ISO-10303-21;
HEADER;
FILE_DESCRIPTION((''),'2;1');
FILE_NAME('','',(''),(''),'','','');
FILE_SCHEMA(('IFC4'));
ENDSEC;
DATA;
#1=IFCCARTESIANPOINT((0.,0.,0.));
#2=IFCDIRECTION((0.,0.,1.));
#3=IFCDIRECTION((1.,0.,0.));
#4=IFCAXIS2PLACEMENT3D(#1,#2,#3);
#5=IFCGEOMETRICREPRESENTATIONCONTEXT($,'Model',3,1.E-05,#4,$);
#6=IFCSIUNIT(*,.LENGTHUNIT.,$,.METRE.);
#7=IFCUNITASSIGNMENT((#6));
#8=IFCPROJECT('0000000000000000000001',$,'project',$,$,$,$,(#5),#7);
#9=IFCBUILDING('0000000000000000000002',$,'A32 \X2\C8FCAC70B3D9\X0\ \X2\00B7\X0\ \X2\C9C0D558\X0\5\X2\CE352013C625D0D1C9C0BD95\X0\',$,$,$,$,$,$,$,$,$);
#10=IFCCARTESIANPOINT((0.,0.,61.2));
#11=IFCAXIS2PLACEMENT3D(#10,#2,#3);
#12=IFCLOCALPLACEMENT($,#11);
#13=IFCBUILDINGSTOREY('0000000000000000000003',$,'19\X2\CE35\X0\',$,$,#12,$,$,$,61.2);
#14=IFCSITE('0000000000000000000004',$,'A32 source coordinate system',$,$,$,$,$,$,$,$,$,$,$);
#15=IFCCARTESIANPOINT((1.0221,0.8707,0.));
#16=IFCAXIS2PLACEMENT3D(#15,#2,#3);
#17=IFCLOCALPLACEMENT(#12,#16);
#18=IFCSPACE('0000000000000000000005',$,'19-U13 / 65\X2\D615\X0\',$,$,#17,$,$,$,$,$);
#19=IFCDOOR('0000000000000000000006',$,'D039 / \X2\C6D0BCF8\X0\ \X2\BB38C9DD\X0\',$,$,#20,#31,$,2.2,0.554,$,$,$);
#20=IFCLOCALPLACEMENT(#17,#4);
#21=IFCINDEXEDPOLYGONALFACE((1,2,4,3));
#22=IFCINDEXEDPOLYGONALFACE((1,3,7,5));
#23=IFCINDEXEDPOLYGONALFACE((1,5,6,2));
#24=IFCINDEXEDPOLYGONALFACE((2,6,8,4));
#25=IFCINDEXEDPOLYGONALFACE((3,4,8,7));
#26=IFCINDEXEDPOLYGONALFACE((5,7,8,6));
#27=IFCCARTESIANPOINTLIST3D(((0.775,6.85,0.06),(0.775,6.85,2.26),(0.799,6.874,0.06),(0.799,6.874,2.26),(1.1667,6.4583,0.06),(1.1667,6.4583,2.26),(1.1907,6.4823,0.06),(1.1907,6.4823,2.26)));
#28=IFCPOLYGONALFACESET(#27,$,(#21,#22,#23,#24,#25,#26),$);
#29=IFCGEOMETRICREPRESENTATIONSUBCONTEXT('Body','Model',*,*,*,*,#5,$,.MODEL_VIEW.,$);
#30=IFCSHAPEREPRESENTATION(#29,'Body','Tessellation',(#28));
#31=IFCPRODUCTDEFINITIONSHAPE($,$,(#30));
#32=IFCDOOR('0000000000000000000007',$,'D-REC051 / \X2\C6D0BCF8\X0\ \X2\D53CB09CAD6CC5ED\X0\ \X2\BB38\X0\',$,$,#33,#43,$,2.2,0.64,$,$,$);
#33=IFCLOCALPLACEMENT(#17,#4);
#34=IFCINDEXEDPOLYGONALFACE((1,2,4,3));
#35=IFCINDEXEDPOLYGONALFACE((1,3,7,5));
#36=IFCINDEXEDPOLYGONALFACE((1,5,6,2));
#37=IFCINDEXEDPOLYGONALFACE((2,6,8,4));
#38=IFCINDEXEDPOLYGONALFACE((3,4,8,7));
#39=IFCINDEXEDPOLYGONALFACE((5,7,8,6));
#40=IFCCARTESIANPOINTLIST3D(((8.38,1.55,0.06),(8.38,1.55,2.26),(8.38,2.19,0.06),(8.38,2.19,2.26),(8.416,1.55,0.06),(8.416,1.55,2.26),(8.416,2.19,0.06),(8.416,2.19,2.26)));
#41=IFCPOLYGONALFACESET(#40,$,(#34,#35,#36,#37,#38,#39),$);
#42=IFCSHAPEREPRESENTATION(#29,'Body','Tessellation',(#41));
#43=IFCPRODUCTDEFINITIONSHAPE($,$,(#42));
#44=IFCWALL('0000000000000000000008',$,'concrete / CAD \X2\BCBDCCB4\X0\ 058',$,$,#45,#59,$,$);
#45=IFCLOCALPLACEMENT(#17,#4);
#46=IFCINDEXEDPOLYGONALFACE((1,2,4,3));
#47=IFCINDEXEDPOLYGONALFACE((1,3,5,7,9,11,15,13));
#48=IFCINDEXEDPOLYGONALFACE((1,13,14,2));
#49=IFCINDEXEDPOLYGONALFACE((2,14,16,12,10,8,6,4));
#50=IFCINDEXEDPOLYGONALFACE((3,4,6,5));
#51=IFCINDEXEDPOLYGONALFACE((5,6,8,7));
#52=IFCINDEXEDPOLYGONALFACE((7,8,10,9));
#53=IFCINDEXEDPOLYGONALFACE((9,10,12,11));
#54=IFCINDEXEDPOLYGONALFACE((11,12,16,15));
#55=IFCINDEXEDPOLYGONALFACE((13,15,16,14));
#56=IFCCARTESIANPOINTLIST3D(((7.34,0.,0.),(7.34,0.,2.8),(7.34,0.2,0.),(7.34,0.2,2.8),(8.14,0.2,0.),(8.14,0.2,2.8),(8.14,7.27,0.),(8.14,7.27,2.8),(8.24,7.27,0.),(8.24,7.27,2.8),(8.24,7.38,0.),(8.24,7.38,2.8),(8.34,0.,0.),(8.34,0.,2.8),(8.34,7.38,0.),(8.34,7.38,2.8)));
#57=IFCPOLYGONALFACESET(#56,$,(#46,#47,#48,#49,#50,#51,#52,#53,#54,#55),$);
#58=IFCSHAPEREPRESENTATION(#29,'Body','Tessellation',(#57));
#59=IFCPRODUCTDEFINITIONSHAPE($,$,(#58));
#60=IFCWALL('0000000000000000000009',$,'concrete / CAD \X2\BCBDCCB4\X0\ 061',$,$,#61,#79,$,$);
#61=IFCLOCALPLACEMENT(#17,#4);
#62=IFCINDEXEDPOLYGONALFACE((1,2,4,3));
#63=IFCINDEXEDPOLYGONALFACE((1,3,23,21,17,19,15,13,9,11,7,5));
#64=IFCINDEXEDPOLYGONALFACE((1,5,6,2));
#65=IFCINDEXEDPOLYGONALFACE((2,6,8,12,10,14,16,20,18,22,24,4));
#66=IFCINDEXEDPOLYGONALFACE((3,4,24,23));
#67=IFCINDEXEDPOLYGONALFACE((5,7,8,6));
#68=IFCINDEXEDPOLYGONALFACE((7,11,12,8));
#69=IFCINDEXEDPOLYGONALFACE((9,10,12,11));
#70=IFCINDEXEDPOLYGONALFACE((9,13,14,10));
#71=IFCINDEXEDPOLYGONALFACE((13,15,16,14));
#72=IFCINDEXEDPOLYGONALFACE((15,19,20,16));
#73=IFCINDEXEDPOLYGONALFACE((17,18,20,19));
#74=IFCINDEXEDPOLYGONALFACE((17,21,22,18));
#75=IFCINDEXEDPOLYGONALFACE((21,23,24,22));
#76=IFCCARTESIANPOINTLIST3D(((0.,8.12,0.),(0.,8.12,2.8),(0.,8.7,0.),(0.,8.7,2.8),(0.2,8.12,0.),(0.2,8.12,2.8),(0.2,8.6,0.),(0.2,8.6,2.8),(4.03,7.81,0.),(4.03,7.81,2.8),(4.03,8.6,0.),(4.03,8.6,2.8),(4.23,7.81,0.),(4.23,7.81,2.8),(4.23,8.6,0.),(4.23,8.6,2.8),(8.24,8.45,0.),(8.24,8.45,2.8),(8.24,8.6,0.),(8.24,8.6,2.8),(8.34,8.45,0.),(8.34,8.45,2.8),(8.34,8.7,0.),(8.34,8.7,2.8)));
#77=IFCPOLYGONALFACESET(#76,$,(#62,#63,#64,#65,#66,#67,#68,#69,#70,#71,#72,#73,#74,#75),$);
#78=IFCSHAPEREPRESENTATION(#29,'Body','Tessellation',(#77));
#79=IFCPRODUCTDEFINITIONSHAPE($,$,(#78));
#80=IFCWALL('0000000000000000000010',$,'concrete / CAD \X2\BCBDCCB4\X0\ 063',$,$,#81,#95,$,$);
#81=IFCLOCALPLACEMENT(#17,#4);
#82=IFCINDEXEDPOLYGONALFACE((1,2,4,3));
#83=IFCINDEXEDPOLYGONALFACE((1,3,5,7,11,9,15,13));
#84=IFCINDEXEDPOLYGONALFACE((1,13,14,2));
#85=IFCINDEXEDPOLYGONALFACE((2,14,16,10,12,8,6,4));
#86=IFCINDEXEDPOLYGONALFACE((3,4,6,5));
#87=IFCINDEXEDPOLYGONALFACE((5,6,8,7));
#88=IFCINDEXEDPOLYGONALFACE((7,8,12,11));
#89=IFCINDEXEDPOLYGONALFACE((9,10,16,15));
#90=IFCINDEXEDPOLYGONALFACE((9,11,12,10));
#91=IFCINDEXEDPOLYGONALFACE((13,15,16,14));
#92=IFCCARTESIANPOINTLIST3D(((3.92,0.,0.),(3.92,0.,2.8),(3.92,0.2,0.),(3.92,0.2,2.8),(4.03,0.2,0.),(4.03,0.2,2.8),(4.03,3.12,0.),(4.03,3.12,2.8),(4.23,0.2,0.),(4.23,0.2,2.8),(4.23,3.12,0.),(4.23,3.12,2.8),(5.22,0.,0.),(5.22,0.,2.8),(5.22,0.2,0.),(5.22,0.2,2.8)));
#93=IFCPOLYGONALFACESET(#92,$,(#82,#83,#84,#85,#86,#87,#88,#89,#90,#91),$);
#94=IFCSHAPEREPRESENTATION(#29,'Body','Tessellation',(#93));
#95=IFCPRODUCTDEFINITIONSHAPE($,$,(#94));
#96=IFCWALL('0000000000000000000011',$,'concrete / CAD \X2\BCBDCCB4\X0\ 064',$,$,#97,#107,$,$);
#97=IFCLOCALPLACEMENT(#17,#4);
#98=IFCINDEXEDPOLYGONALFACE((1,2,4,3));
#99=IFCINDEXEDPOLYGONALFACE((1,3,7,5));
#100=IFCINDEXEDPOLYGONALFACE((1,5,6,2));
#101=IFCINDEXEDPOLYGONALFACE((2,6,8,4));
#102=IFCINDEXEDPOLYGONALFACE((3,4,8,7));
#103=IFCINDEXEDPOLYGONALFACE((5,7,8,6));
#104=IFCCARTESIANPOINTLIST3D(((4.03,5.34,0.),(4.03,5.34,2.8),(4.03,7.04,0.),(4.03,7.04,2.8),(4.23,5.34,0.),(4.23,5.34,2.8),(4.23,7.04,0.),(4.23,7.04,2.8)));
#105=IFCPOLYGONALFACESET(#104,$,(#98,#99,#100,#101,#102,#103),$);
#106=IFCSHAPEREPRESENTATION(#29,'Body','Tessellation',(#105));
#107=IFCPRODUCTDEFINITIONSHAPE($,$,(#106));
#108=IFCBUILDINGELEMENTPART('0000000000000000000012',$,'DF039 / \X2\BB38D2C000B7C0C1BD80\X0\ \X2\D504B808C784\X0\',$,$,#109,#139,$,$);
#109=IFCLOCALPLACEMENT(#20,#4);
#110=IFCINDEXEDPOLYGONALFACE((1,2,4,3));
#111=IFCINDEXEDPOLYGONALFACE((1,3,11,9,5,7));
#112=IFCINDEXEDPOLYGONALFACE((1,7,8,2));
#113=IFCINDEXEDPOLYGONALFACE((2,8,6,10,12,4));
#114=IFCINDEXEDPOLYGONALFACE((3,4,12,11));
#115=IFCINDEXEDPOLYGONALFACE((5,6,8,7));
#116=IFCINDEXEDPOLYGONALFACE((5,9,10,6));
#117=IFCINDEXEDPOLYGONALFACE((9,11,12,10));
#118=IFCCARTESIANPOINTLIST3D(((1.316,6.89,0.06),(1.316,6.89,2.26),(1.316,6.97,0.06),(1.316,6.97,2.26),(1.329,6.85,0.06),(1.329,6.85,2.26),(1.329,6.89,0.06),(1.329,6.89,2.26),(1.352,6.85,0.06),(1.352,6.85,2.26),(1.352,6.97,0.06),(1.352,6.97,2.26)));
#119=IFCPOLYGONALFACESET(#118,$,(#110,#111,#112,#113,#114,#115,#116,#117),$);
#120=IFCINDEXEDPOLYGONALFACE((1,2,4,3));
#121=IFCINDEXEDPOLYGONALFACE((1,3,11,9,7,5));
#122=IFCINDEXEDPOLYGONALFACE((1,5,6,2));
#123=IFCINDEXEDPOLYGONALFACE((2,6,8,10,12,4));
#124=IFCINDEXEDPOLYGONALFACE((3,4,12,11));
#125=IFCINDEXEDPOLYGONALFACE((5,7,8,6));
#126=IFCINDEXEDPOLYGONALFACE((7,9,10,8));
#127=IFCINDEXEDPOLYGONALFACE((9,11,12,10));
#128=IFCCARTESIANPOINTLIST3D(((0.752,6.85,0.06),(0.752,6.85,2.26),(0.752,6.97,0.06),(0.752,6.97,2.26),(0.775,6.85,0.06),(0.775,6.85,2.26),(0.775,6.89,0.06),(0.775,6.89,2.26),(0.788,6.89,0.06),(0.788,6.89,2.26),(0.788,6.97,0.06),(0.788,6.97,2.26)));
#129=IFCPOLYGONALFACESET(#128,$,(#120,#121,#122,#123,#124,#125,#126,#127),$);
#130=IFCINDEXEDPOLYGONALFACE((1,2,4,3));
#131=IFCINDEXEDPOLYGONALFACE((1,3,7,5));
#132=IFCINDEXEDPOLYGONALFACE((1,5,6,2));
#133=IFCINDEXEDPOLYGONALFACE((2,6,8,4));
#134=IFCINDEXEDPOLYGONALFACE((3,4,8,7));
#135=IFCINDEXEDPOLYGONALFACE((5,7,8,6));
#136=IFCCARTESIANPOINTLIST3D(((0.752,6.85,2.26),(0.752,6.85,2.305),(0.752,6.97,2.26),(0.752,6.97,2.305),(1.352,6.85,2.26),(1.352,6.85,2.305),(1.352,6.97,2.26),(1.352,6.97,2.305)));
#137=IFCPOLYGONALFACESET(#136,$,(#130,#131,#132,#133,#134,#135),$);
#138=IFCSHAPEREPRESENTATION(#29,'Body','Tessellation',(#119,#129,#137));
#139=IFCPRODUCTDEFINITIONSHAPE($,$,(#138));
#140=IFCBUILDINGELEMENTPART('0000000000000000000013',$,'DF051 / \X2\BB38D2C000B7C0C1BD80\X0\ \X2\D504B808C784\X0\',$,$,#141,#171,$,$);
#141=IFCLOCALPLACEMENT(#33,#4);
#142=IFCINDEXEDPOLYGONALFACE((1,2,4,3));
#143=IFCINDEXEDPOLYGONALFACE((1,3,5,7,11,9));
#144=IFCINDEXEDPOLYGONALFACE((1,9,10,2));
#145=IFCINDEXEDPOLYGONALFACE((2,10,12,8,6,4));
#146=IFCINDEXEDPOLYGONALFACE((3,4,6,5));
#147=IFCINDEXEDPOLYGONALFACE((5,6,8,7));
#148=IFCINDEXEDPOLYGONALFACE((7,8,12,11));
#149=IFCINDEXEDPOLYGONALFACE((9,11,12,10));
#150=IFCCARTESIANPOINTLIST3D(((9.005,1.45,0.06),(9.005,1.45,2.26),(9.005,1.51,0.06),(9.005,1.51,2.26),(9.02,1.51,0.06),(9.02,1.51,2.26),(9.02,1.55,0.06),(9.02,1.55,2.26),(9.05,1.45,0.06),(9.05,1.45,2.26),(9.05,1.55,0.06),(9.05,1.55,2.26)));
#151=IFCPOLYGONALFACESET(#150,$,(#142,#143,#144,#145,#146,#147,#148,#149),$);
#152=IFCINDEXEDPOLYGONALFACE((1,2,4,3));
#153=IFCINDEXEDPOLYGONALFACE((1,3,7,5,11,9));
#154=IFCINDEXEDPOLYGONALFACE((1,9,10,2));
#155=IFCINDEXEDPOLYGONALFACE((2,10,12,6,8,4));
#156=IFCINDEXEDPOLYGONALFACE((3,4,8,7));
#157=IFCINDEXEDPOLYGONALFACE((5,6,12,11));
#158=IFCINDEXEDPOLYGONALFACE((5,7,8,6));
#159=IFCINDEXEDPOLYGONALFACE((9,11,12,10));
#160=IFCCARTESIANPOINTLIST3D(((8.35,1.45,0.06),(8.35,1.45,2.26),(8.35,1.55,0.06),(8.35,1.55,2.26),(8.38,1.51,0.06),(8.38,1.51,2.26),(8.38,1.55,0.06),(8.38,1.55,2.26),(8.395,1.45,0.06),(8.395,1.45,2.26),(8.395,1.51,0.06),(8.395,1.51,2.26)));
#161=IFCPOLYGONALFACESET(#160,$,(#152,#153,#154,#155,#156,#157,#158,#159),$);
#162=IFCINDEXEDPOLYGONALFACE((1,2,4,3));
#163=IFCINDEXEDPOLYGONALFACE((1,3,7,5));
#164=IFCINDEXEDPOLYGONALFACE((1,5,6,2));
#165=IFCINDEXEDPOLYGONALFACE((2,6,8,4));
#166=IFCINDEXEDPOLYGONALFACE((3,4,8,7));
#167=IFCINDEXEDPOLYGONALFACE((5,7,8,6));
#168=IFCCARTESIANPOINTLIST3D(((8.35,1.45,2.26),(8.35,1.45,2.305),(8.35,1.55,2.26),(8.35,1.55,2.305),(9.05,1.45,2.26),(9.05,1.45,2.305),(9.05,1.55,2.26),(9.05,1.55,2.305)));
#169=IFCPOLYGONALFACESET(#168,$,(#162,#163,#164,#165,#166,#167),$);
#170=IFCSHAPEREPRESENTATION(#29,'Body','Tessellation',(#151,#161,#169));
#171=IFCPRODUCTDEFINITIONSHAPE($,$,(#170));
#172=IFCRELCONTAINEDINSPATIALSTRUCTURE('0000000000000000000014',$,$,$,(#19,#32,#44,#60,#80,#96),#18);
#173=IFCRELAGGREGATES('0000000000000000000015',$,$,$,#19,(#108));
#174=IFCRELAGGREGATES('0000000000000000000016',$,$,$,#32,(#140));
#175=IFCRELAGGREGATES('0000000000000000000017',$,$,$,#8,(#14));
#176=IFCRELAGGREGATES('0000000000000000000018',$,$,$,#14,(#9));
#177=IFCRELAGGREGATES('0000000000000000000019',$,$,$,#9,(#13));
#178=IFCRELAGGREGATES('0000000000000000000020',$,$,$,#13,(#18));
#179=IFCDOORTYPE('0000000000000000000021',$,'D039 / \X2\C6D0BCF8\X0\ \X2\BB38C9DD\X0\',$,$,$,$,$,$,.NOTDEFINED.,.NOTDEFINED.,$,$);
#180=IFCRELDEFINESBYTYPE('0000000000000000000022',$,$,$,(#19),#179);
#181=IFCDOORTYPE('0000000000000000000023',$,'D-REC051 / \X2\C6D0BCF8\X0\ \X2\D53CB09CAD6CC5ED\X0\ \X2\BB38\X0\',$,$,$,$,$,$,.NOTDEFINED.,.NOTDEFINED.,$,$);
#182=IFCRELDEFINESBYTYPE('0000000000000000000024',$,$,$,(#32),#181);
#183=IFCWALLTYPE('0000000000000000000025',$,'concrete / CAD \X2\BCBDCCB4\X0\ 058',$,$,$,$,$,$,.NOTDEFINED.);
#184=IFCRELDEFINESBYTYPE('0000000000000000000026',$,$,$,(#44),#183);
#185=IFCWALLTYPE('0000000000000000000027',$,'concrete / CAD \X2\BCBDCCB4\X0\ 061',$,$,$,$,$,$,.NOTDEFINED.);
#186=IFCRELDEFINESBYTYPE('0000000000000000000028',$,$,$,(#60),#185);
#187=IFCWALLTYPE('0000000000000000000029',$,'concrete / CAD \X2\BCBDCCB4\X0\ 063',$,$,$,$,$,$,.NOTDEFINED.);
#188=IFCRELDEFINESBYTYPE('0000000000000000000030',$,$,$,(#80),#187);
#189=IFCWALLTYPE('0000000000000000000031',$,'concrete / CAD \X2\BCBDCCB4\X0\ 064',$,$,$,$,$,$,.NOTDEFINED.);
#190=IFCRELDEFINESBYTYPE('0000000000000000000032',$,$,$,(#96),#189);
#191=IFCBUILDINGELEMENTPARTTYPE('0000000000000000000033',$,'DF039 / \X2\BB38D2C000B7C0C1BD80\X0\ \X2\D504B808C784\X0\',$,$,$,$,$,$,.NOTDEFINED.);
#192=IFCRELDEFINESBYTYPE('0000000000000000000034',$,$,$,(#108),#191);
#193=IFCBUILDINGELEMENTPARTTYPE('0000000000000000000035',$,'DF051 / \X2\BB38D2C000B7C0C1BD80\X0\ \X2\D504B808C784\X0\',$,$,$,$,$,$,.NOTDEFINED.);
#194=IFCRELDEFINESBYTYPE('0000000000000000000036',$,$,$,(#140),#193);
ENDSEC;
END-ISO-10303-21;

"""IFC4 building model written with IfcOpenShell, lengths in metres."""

from ifc_helpers import new_model, si_unit, frame, origin, origin_with_axes, place, context, subcontext, project, spatial, polyline, outline, extrude, source, transform, mapped, type_object, type_shapes, element, aggregate, save


model = new_model("IFC4")

# Units and contexts
model_context = context("Model", 3, precision=1e-05, world=origin_with_axes())
body_context = subcontext(model_context, "Body", "Model", "MODEL_VIEW")
ifc_project = project(units=[si_unit("LENGTHUNIT", "METRE")], contexts=[model_context])

# Site, building, storey, space
storey_placement = place(None, frame((0.0, 0.0, 61.2), z_axis=(0.0, 0.0, 1.0), x_axis=(1.0, 0.0, 0.0)))
space_placement = place(storey_placement, frame((1.0221, 0.8707, 0.0), z_axis=(0.0, 0.0, 1.0), x_axis=(1.0, 0.0, 0.0)))
site = spatial("IfcSite", under=ifc_project, Name="A32 source coordinate system")
building = spatial("IfcBuilding", under=site, Name="A32 주거동 · 지하5층–옥탑지붕")
storey = spatial("IfcBuildingStorey", under=building, at=storey_placement, Name="19층", Elevation=61.2)
space = spatial("IfcSpace", under=storey, at=space_placement, Name="19-U13 / 65형")

# Doors
door_type_1 = type_object("IfcDoorType", Name="D039 / 원본 문짝", OperationType="NOTDEFINED", PredefinedType="NOTDEFINED")
shared_shape_1 = source(origin(), body_context, "Body", "SweptSolid", [
    extrude(outline(polyline([(1.1907, 6.4823), (1.1667, 6.4583), (0.775, 6.85), (0.799, 6.874), (1.1907, 6.4823)])), frame((0.0, 0.0, 0.06)), (0.0, 0.0, 1.0), 2.2),
])
type_shapes(door_type_1, [shared_shape_1])
door_1_placement = place(space_placement, origin_with_axes())
door_1 = element("IfcDoor", 1, at=door_1_placement, inside=space, type_object=door_type_1, Name="D039 / 원본 문짝", OverallHeight=2.2, OverallWidth=0.554, context=body_context, shape_type="MappedRepresentation", body=[
    mapped(shared_shape_1, transform((0.0, 0.0, 0.0), scale=1.0)),
])
door_type_2 = type_object("IfcDoorType", Name="D-REC051 / 원본 피난구역 문", OperationType="NOTDEFINED", PredefinedType="NOTDEFINED")
shared_shape_2 = source(origin(), body_context, "Body", "SweptSolid", [
    extrude(outline(polyline([(8.416, 2.19), (8.416, 1.55), (8.38, 1.55), (8.38, 2.19), (8.416, 2.19)])), frame((0.0, 0.0, 0.06)), (0.0, 0.0, 1.0), 2.2),
])
type_shapes(door_type_2, [shared_shape_2])
door_2_placement = place(space_placement, origin_with_axes())
door_2 = element("IfcDoor", 2, at=door_2_placement, inside=space, type_object=door_type_2, Name="D-REC051 / 원본 피난구역 문", OverallHeight=2.2, OverallWidth=0.64, context=body_context, shape_type="MappedRepresentation", body=[
    mapped(shared_shape_2, transform((0.0, 0.0, 0.0), scale=1.0)),
])

# Walls
wall_type_1 = type_object("IfcWallType", Name="concrete / CAD 벽체 058", PredefinedType="NOTDEFINED")
shared_shape_3 = source(origin(), body_context, "Body", "SweptSolid", [
    extrude(outline(polyline([(8.34, 0.0), (7.34, 0.0), (7.34, 0.2), (8.14, 0.2), (8.14, 7.27), (8.24, 7.27), (8.24, 7.38), (8.34, 7.38), (8.34, 0.0)])), origin(), (0.0, 0.0, 1.0), 2.8),
])
type_shapes(wall_type_1, [shared_shape_3])
wall_1_placement = place(space_placement, origin_with_axes())
element("IfcWall", 3, at=wall_1_placement, inside=space, type_object=wall_type_1, Name="concrete / CAD 벽체 058", context=body_context, shape_type="MappedRepresentation", body=[
    mapped(shared_shape_3, transform((0.0, 0.0, 0.0), scale=1.0)),
])
wall_type_2 = type_object("IfcWallType", Name="concrete / CAD 벽체 061", PredefinedType="NOTDEFINED")
shared_shape_4 = source(origin(), body_context, "Body", "SweptSolid", [
    extrude(outline(polyline([(0.2, 8.6), (0.2, 8.12), (0.0, 8.12), (0.0, 8.7), (8.34, 8.7), (8.34, 8.45), (8.24, 8.45), (8.24, 8.6), (4.23, 8.6), (4.23, 7.81), (4.03, 7.81), (4.03, 8.6), (0.2, 8.6)])), origin(), (0.0, 0.0, 1.0), 2.8),
])
type_shapes(wall_type_2, [shared_shape_4])
wall_2_placement = place(space_placement, origin_with_axes())
element("IfcWall", 4, at=wall_2_placement, inside=space, type_object=wall_type_2, Name="concrete / CAD 벽체 061", context=body_context, shape_type="MappedRepresentation", body=[
    mapped(shared_shape_4, transform((0.0, 0.0, 0.0), scale=1.0)),
])
wall_type_3 = type_object("IfcWallType", Name="concrete / CAD 벽체 063", PredefinedType="NOTDEFINED")
shared_shape_5 = source(origin(), body_context, "Body", "SweptSolid", [
    extrude(outline(polyline([(5.22, 0.0), (3.92, 0.0), (3.92, 0.2), (4.03, 0.2), (4.03, 3.12), (4.23, 3.12), (4.23, 0.2), (5.22, 0.2), (5.22, 0.0)])), origin(), (0.0, 0.0, 1.0), 2.8),
])
type_shapes(wall_type_3, [shared_shape_5])
wall_3_placement = place(space_placement, origin_with_axes())
element("IfcWall", 5, at=wall_3_placement, inside=space, type_object=wall_type_3, Name="concrete / CAD 벽체 063", context=body_context, shape_type="MappedRepresentation", body=[
    mapped(shared_shape_5, transform((0.0, 0.0, 0.0), scale=1.0)),
])
wall_type_4 = type_object("IfcWallType", Name="concrete / CAD 벽체 064", PredefinedType="NOTDEFINED")
shared_shape_6 = source(origin(), body_context, "Body", "SweptSolid", [
    extrude(outline(polyline([(4.03, 7.04), (4.23, 7.04), (4.23, 5.34), (4.03, 5.34), (4.03, 7.04)])), origin(), (0.0, 0.0, 1.0), 2.8),
])
type_shapes(wall_type_4, [shared_shape_6])
wall_4_placement = place(space_placement, origin_with_axes())
element("IfcWall", 6, at=wall_4_placement, inside=space, type_object=wall_type_4, Name="concrete / CAD 벽체 064", context=body_context, shape_type="MappedRepresentation", body=[
    mapped(shared_shape_6, transform((0.0, 0.0, 0.0), scale=1.0)),
])

# Building element parts
building_element_part_type_1 = type_object("IfcBuildingElementPartType", Name="DF039 / 문틀·상부 프레임", PredefinedType="NOTDEFINED")
shared_shape_7 = source(origin(), body_context, "Body", "SweptSolid", [
    extrude(outline(polyline([(1.352, 6.85), (1.329, 6.85), (1.329, 6.89), (1.316, 6.89), (1.316, 6.97), (1.352, 6.97), (1.352, 6.85)])), frame((0.0, 0.0, 0.06)), (0.0, 0.0, 1.0), 2.2),
    extrude(outline(polyline([(0.788, 6.97), (0.788, 6.89), (0.775, 6.89), (0.775, 6.85), (0.752, 6.85), (0.752, 6.97), (0.788, 6.97)])), frame((0.0, 0.0, 0.06)), (0.0, 0.0, 1.0), 2.2),
    extrude(outline(polyline([(0.752, 6.85), (0.752, 6.97), (1.352, 6.97), (1.352, 6.85), (0.752, 6.85)])), frame((0.0, 0.0, 2.26)), (0.0, 0.0, 1.0), 0.045),
])
type_shapes(building_element_part_type_1, [shared_shape_7])
building_element_part_1_placement = place(door_1_placement, origin_with_axes())
building_element_part_1 = element("IfcBuildingElementPart", 7, at=building_element_part_1_placement, type_object=building_element_part_type_1, Name="DF039 / 문틀·상부 프레임", context=body_context, shape_type="MappedRepresentation", body=[
    mapped(shared_shape_7, transform((0.0, 0.0, 0.0), scale=1.0)),
])
aggregate(door_1, [building_element_part_1])
building_element_part_type_2 = type_object("IfcBuildingElementPartType", Name="DF051 / 문틀·상부 프레임", PredefinedType="NOTDEFINED")
shared_shape_8 = source(origin(), body_context, "Body", "SweptSolid", [
    extrude(outline(polyline([(9.05, 1.45), (9.005, 1.45), (9.005, 1.51), (9.02, 1.51), (9.02, 1.55), (9.05, 1.55), (9.05, 1.45)])), frame((0.0, 0.0, 0.06)), (0.0, 0.0, 1.0), 2.2),
    extrude(outline(polyline([(8.38, 1.55), (8.38, 1.51), (8.395, 1.51), (8.395, 1.45), (8.35, 1.45), (8.35, 1.55), (8.38, 1.55)])), frame((0.0, 0.0, 0.06)), (0.0, 0.0, 1.0), 2.2),
    extrude(outline(polyline([(8.35, 1.45), (8.35, 1.55), (9.05, 1.55), (9.05, 1.45), (8.35, 1.45)])), frame((0.0, 0.0, 2.26)), (0.0, 0.0, 1.0), 0.045),
])
type_shapes(building_element_part_type_2, [shared_shape_8])
building_element_part_2_placement = place(door_2_placement, origin_with_axes())
building_element_part_2 = element("IfcBuildingElementPart", 8, at=building_element_part_2_placement, type_object=building_element_part_type_2, Name="DF051 / 문틀·상부 프레임", context=body_context, shape_type="MappedRepresentation", body=[
    mapped(shared_shape_8, transform((0.0, 0.0, 0.0), scale=1.0)),
])
aggregate(door_2, [building_element_part_2])

save(model, "model.ifc")
